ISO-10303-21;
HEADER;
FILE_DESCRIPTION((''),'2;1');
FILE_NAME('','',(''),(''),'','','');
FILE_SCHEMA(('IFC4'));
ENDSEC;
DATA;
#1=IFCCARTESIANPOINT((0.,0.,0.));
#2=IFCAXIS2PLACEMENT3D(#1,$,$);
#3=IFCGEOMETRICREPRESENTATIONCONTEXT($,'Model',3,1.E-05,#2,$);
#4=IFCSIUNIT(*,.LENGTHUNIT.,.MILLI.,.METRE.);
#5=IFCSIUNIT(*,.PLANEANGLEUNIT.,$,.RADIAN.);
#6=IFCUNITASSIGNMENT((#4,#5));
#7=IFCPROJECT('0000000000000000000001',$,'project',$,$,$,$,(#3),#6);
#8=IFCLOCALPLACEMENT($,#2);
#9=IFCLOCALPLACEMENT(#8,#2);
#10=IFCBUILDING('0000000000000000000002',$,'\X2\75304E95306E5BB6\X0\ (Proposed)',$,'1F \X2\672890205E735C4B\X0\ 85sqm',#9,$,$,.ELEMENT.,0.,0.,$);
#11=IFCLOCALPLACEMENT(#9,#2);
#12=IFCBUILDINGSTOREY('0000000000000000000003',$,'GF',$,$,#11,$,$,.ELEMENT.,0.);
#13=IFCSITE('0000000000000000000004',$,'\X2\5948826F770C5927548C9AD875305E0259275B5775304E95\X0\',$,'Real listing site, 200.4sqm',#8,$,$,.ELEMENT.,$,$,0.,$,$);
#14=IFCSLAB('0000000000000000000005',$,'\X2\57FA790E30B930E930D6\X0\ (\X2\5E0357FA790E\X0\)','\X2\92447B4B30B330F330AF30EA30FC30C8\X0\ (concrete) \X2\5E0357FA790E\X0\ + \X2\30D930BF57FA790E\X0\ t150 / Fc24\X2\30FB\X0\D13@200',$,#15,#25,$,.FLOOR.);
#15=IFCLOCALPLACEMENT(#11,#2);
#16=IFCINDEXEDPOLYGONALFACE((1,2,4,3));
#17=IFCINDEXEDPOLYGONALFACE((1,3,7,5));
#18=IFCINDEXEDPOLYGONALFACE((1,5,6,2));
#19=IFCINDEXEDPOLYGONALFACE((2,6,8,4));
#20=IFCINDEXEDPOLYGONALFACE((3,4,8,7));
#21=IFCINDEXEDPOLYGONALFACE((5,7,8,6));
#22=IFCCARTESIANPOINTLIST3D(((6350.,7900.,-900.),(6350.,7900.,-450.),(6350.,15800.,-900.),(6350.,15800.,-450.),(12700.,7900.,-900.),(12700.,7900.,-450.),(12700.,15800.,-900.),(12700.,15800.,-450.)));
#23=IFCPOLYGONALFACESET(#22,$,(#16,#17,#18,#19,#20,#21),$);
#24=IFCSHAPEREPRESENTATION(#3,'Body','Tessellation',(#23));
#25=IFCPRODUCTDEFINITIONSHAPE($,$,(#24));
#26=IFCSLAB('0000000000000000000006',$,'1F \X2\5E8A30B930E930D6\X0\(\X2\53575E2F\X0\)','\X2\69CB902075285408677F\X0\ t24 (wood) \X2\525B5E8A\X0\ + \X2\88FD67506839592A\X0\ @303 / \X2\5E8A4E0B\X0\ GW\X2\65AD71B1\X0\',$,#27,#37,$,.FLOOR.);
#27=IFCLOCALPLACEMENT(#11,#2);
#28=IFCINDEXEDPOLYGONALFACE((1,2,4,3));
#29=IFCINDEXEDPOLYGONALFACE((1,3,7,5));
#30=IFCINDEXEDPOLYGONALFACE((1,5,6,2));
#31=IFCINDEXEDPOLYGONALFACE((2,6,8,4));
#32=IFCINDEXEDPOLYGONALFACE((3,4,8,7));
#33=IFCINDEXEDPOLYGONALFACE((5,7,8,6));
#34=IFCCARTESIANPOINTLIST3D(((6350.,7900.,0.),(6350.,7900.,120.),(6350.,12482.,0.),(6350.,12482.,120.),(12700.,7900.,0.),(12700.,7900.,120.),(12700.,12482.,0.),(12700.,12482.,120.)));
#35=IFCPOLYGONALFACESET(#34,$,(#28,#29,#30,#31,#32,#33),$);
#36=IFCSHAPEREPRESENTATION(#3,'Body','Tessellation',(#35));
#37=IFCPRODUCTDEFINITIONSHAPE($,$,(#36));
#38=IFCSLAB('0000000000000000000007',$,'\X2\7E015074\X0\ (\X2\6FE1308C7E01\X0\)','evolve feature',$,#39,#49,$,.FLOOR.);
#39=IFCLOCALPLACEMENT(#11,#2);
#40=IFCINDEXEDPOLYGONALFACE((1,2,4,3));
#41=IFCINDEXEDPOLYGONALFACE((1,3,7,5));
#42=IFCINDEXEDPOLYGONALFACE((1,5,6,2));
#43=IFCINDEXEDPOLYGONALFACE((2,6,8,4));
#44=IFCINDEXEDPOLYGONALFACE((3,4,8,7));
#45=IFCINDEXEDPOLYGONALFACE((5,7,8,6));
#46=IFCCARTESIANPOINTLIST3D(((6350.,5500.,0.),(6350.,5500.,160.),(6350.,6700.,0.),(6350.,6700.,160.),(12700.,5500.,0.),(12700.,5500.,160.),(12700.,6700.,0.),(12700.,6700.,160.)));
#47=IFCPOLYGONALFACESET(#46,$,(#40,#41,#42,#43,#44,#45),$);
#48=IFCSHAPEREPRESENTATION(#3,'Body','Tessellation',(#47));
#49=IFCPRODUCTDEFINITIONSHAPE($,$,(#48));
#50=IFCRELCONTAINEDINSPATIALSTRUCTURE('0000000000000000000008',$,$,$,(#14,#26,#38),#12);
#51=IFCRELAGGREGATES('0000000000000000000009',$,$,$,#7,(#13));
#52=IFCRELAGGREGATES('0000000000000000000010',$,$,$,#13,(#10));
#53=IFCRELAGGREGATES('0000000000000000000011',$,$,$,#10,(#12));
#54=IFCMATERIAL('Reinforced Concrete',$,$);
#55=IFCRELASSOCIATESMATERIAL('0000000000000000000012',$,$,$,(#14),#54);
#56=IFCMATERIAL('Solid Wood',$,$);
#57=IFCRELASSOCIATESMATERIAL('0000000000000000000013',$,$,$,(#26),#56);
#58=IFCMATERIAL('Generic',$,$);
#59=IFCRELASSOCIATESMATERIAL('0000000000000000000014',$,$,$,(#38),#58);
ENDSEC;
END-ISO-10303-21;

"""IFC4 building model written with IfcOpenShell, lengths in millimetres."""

from ifc_helpers import new_model, si_unit, frame, frame_2d, origin, place, context, project, spatial, rectangle, extrude, material, element, save


model = new_model("IFC4")

# Units and contexts
model_context = context("Model", 3, precision=1e-05, world=origin())
ifc_project = project(units=[si_unit("LENGTHUNIT", "METRE", prefix="MILLI"), si_unit("PLANEANGLEUNIT", "RADIAN")], contexts=[model_context])

# Site, building, storey
site_placement = place(None, origin())
site = spatial("IfcSite", under=ifc_project, at=site_placement, Name="奈良県大和高田市大字田井", ObjectType="Real listing site, 200.4sqm", CompositionType="ELEMENT", RefElevation=0.0)
building_placement = place(site_placement, origin())
building = spatial("IfcBuilding", under=site, at=building_placement, Name="田井の家 (Proposed)", ObjectType="1F 木造平屋 85sqm", CompositionType="ELEMENT", ElevationOfRefHeight=0.0, ElevationOfTerrain=0.0)
storey_placement = place(building_placement, origin())
storey = spatial("IfcBuildingStorey", under=building, at=storey_placement, Name="GF", CompositionType="ELEMENT", Elevation=0.0)

# Slabs
ifc_material_1 = material(Name="Reinforced Concrete")
slab_1_placement = place(storey_placement, frame((3175.0, 3950.0, -450.0)))
element("IfcSlab", 1, at=slab_1_placement, inside=storey, material=ifc_material_1, Name="基礎スラブ (布基礎)", Description="鉄筋コンクリート (concrete) 布基礎 + ベタ基礎 t150 / Fc24・D13@200", PredefinedType="FLOOR", context=model_context, shape_type="SweptSolid", body=[
    extrude(rectangle(XDim=6350.0, YDim=7900.0, at=frame_2d((3175.0, 3950.0))), frame((3175.0, 3950.0, -450.0)), (0.0, 0.0, 1.0), 450.0),
])
ifc_material_2 = material(Name="Solid Wood")
slab_2_placement = place(storey_placement, frame((3175.0, 3950.0, 0.0)))
element("IfcSlab", 2, at=slab_2_placement, inside=storey, material=ifc_material_2, Name="1F 床スラブ(南帯)", Description="構造用合板 t24 (wood) 剛床 + 製材根太 @303 / 床下 GW断熱", PredefinedType="FLOOR", context=model_context, shape_type="SweptSolid", body=[
    extrude(rectangle(XDim=6350.0, YDim=4582.0, at=frame_2d((3175.0, 2291.0))), frame((3175.0, 3950.0, 0.0)), (0.0, 0.0, 1.0), 120.0),
])
ifc_material_3 = material(Name="Generic")
slab_3_placement = place(storey_placement, frame((3175.0, 2750.0, 0.0)))
element("IfcSlab", 3, at=slab_3_placement, inside=storey, material=ifc_material_3, Name="縁側 (濡れ縁)", Description="evolve feature", PredefinedType="FLOOR", context=model_context, shape_type="SweptSolid", body=[
    extrude(rectangle(XDim=6350.0, YDim=1200.0, at=frame_2d((3175.0, 600.0))), frame((3175.0, 2750.0, 0.0)), (0.0, 0.0, 1.0), 160.0),
])

save(model, "model.ifc")
